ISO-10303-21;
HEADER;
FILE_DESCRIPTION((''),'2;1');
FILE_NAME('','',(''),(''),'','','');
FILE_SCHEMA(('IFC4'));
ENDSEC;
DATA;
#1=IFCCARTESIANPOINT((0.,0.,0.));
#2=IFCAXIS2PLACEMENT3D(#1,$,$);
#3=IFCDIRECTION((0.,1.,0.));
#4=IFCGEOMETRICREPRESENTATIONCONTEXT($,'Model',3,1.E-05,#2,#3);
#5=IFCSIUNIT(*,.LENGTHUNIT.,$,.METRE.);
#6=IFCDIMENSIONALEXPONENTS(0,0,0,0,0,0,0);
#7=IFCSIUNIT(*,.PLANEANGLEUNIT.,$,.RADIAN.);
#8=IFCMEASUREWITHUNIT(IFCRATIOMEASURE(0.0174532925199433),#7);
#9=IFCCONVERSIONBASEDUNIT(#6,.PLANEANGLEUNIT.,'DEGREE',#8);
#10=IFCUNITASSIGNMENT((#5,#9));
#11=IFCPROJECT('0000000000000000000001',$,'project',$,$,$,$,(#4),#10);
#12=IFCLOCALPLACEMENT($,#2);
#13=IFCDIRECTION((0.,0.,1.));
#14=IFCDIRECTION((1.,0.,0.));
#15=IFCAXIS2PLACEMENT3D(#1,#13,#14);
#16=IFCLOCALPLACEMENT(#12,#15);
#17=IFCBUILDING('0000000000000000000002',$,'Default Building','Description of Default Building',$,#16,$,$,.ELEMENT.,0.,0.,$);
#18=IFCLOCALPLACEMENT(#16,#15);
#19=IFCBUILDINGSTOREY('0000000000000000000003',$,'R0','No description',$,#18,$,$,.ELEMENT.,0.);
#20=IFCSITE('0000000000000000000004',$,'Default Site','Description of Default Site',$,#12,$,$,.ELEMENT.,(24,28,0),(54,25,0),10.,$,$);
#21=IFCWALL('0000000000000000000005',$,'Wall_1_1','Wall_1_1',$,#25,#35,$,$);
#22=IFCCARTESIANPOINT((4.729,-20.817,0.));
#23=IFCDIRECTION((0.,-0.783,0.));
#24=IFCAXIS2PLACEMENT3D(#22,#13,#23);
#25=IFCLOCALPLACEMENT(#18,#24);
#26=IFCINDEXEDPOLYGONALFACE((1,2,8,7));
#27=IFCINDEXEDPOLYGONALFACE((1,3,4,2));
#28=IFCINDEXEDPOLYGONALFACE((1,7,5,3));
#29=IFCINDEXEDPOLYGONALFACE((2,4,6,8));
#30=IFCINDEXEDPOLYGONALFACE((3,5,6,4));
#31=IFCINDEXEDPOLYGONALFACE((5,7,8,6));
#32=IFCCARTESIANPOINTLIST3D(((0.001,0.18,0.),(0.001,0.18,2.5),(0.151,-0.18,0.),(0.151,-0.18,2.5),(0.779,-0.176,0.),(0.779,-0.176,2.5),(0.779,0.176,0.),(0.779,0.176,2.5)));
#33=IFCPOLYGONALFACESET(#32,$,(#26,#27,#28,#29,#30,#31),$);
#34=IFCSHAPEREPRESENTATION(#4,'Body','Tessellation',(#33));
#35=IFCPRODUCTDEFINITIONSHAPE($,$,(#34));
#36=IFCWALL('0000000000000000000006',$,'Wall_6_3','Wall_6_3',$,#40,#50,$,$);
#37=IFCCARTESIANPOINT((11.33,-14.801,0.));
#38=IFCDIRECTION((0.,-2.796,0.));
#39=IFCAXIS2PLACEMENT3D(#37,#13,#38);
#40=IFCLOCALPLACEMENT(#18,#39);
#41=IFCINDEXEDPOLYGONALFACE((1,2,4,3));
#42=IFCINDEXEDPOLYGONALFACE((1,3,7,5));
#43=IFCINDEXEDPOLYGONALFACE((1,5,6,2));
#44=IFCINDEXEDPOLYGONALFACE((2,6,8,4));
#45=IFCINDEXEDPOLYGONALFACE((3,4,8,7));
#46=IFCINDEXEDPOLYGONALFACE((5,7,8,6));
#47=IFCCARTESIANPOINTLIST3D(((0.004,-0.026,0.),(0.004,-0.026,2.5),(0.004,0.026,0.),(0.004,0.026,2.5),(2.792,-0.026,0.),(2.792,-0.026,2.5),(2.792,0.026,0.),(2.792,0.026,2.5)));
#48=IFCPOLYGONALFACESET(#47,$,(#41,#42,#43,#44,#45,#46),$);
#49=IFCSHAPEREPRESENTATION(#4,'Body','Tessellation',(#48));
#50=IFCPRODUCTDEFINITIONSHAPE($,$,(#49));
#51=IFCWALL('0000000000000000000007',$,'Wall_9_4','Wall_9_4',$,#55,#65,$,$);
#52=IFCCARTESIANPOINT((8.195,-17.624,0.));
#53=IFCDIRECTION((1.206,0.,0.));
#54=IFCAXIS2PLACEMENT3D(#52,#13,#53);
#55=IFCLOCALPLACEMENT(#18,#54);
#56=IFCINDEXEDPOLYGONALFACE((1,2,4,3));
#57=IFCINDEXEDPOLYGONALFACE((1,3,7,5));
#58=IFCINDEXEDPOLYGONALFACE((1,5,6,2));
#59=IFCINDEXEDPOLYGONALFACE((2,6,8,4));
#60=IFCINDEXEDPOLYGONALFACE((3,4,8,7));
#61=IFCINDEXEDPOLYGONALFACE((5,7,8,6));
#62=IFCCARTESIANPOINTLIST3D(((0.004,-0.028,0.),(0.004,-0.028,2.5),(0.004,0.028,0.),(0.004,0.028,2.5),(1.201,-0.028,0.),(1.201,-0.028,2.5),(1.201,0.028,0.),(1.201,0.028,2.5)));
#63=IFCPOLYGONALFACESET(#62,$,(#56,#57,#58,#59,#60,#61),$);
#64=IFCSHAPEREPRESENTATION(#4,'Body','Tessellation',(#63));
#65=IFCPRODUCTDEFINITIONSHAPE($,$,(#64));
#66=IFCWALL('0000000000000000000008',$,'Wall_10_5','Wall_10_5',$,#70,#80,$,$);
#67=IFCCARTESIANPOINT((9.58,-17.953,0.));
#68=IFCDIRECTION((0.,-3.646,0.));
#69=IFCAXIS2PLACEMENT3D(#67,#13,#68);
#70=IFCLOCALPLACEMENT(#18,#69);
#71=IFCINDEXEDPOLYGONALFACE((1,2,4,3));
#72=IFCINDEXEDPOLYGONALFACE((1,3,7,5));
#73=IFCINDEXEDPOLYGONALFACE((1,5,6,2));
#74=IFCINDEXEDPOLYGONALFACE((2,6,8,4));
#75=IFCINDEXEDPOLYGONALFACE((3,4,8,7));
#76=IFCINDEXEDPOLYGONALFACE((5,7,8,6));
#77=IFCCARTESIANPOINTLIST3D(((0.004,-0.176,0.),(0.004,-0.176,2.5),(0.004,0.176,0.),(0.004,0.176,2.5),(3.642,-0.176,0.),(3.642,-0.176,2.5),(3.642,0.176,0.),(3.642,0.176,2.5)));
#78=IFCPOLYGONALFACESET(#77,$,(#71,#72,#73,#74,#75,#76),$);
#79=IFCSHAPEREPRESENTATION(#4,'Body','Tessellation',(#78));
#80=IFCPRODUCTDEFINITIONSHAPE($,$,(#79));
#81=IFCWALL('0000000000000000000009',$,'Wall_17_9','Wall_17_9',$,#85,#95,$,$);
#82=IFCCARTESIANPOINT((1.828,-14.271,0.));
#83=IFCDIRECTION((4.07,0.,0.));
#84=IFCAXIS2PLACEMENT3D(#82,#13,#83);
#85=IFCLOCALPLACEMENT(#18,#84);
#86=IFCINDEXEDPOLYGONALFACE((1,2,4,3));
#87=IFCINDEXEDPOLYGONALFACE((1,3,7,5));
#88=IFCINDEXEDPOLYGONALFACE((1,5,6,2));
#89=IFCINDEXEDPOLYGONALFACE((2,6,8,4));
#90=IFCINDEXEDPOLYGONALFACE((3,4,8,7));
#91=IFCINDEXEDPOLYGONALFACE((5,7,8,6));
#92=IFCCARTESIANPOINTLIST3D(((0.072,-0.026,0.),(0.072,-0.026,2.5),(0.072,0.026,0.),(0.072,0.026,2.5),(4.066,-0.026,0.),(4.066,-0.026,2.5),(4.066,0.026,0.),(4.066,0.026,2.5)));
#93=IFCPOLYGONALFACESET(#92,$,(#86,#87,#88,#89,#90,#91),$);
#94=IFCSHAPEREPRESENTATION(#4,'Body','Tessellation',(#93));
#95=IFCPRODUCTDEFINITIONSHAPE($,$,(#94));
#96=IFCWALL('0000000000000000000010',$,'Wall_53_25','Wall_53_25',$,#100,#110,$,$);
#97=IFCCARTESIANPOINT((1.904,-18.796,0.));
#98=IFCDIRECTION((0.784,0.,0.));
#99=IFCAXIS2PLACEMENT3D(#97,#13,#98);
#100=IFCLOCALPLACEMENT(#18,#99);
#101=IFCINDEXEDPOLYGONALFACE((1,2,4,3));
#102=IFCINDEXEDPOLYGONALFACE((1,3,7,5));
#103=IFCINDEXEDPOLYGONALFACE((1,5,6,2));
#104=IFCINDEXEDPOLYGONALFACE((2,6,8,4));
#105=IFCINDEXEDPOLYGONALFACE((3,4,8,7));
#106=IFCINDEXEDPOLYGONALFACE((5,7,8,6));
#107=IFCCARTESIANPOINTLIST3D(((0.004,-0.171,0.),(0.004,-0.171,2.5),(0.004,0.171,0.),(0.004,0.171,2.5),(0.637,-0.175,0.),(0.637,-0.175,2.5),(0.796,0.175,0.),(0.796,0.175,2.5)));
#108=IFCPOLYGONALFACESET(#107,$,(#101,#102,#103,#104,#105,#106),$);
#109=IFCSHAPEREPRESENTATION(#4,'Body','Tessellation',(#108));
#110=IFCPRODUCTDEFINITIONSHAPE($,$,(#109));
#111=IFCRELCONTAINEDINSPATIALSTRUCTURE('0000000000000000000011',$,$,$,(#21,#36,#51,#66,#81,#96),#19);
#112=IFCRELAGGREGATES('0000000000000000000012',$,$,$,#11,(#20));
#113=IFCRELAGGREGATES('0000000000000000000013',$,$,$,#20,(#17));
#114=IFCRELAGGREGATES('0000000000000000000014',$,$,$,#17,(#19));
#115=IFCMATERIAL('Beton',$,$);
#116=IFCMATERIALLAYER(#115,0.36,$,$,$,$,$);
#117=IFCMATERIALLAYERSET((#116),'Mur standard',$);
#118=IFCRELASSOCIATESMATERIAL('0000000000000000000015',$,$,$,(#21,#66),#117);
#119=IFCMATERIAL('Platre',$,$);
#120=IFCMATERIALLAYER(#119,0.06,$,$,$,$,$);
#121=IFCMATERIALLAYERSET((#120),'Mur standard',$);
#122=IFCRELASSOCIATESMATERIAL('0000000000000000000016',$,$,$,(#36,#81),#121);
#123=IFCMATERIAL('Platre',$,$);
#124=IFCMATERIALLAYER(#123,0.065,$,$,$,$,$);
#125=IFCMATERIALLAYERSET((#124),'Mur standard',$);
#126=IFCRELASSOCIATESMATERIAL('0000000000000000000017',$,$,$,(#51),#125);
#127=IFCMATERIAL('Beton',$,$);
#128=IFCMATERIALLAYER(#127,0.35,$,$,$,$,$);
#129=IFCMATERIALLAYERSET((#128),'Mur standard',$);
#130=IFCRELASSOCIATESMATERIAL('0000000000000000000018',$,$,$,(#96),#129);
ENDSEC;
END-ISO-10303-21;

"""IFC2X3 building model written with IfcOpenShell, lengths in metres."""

from ifc_helpers import new_model, entity, si_unit, converted_unit, direction, frame, origin, origin_with_axes, place, context, project, spatial, polyline, outline, extrude, material, layer, layer_set, layer_usage, element, save


model = new_model("IFC2X3")

# Units and contexts
model_context = context("Model", 3, precision=1e-05, world=origin(), true_north=direction((0.0, 1.0, 0.0)))
ifc_project = project(units=[si_unit("LENGTHUNIT", "METRE"), converted_unit("PLANEANGLEUNIT", "DEGREE", entity("IfcRatioMeasure", 0.0174532925199433), si_unit("PLANEANGLEUNIT", "RADIAN"), dimensions=[0, 0, 0, 0, 0, 0, 0])], contexts=[model_context])

# Site, building, storey
site_placement = place(None, origin())
site = spatial("IfcSite", under=ifc_project, at=site_placement, Name="Default Site", Description="Description of Default Site", CompositionType="ELEMENT", RefLatitude=(24, 28, 0), RefLongitude=(54, 25, 0), RefElevation=10.0)
building_placement = place(site_placement, origin_with_axes())
building = spatial("IfcBuilding", under=site, at=building_placement, Name="Default Building", Description="Description of Default Building", CompositionType="ELEMENT", ElevationOfRefHeight=0.0, ElevationOfTerrain=0.0)
storey_placement = place(building_placement, origin_with_axes())
storey = spatial("IfcBuildingStorey", under=building, at=storey_placement, Name="R0", Description="No description", CompositionType="ELEMENT", Elevation=0.0)

# Wall
ifc_material_1 = material(Name="Beton")
ifc_layer_1 = layer(ifc_material_1, 0.36)
ifc_layer_set_1 = layer_set([ifc_layer_1], Name="Mur standard")
ifc_layer_usage_1 = layer_usage(ifc_layer_set_1, "AXIS2", "NEGATIVE", 0.36)
wall_1_placement = place(storey_placement, frame((4.729, -20.817, 0.0), z_axis=(0.0, 0.0, 1.0), x_axis=(0.0, -0.783, 0.0)))
element("IfcWall", 1, at=wall_1_placement, inside=storey, material=ifc_layer_usage_1, Name="Wall_1_1", Description="Wall_1_1", context=model_context, shape_type="SweptSolid", body=[
    extrude(outline(polyline([(0.001, 0.18), (0.151, -0.18), (0.779, -0.176), (0.779, 0.176), (0.001, 0.18)])), origin(), (0.0, 0.0, 1.0), 2.5),
])

# Walls
ifc_material_2 = material(Name="Platre")
ifc_layer_2 = layer(ifc_material_2, 0.06)
ifc_layer_set_2 = layer_set([ifc_layer_2], Name="Mur standard")
ifc_layer_usage_2 = layer_usage(ifc_layer_set_2, "AXIS2", "NEGATIVE", 0.06)
wall_2_placement = place(storey_placement, frame((11.33, -14.801, 0.0), z_axis=(0.0, 0.0, 1.0), x_axis=(0.0, -2.796, 0.0)))
element("IfcWall", 2, at=wall_2_placement, inside=storey, material=ifc_layer_usage_2, Name="Wall_6_3", Description="Wall_6_3", context=model_context, shape_type="SweptSolid", body=[
    extrude(outline(polyline([(0.004, -0.026), (2.792, -0.026), (2.792, 0.026), (0.004, 0.026), (0.004, -0.026)])), origin(), (0.0, 0.0, 1.0), 2.5),
])
ifc_material_3 = material(Name="Platre")
ifc_layer_3 = layer(ifc_material_3, 0.065)
ifc_layer_set_3 = layer_set([ifc_layer_3], Name="Mur standard")
ifc_layer_usage_3 = layer_usage(ifc_layer_set_3, "AXIS2", "NEGATIVE", 0.065)
wall_3_placement = place(storey_placement, frame((8.195, -17.624, 0.0), z_axis=(0.0, 0.0, 1.0), x_axis=(1.206, 0.0, 0.0)))
element("IfcWall", 3, at=wall_3_placement, inside=storey, material=ifc_layer_usage_3, Name="Wall_9_4", Description="Wall_9_4", context=model_context, shape_type="SweptSolid", body=[
    extrude(outline(polyline([(0.004, 0.028), (0.004, -0.028), (1.201, -0.028), (1.201, 0.028), (0.004, 0.028)])), origin(), (0.0, 0.0, 1.0), 2.5),
])
wall_4_placement = place(storey_placement, frame((9.58, -17.953, 0.0), z_axis=(0.0, 0.0, 1.0), x_axis=(0.0, -3.646, 0.0)))
element("IfcWall", 4, at=wall_4_placement, inside=storey, material=ifc_layer_usage_1, Name="Wall_10_5", Description="Wall_10_5", context=model_context, shape_type="SweptSolid", body=[
    extrude(outline(polyline([(0.004, -0.176), (3.642, -0.176), (3.642, 0.176), (0.004, 0.176), (0.004, -0.176)])), origin(), (0.0, 0.0, 1.0), 2.5),
])

# Wall
wall_5_placement = place(storey_placement, frame((1.828, -14.271, 0.0), z_axis=(0.0, 0.0, 1.0), x_axis=(4.07, 0.0, 0.0)))
element("IfcWall", 5, at=wall_5_placement, inside=storey, material=ifc_layer_usage_2, Name="Wall_17_9", Description="Wall_17_9", context=model_context, shape_type="SweptSolid", body=[
    extrude(outline(polyline([(0.072, 0.026), (0.072, -0.026), (4.066, -0.026), (4.066, 0.026), (0.072, 0.026)])), origin(), (0.0, 0.0, 1.0), 2.5),
])

# Wall
ifc_material_4 = material(Name="Beton")
ifc_layer_4 = layer(ifc_material_4, 0.35)
ifc_layer_set_4 = layer_set([ifc_layer_4], Name="Mur standard")
ifc_layer_usage_4 = layer_usage(ifc_layer_set_4, "AXIS2", "NEGATIVE", 0.35)
wall_6_placement = place(storey_placement, frame((1.904, -18.796, 0.0), z_axis=(0.0, 0.0, 1.0), x_axis=(0.784, 0.0, 0.0)))
element("IfcWall", 6, at=wall_6_placement, inside=storey, material=ifc_layer_usage_4, Name="Wall_53_25", Description="Wall_53_25", context=model_context, shape_type="SweptSolid", body=[
    extrude(outline(polyline([(0.796, 0.175), (0.004, 0.171), (0.004, -0.171), (0.637, -0.175), (0.796, 0.175)])), origin(), (0.0, 0.0, 1.0), 2.5),
])

save(model, "model.ifc")
